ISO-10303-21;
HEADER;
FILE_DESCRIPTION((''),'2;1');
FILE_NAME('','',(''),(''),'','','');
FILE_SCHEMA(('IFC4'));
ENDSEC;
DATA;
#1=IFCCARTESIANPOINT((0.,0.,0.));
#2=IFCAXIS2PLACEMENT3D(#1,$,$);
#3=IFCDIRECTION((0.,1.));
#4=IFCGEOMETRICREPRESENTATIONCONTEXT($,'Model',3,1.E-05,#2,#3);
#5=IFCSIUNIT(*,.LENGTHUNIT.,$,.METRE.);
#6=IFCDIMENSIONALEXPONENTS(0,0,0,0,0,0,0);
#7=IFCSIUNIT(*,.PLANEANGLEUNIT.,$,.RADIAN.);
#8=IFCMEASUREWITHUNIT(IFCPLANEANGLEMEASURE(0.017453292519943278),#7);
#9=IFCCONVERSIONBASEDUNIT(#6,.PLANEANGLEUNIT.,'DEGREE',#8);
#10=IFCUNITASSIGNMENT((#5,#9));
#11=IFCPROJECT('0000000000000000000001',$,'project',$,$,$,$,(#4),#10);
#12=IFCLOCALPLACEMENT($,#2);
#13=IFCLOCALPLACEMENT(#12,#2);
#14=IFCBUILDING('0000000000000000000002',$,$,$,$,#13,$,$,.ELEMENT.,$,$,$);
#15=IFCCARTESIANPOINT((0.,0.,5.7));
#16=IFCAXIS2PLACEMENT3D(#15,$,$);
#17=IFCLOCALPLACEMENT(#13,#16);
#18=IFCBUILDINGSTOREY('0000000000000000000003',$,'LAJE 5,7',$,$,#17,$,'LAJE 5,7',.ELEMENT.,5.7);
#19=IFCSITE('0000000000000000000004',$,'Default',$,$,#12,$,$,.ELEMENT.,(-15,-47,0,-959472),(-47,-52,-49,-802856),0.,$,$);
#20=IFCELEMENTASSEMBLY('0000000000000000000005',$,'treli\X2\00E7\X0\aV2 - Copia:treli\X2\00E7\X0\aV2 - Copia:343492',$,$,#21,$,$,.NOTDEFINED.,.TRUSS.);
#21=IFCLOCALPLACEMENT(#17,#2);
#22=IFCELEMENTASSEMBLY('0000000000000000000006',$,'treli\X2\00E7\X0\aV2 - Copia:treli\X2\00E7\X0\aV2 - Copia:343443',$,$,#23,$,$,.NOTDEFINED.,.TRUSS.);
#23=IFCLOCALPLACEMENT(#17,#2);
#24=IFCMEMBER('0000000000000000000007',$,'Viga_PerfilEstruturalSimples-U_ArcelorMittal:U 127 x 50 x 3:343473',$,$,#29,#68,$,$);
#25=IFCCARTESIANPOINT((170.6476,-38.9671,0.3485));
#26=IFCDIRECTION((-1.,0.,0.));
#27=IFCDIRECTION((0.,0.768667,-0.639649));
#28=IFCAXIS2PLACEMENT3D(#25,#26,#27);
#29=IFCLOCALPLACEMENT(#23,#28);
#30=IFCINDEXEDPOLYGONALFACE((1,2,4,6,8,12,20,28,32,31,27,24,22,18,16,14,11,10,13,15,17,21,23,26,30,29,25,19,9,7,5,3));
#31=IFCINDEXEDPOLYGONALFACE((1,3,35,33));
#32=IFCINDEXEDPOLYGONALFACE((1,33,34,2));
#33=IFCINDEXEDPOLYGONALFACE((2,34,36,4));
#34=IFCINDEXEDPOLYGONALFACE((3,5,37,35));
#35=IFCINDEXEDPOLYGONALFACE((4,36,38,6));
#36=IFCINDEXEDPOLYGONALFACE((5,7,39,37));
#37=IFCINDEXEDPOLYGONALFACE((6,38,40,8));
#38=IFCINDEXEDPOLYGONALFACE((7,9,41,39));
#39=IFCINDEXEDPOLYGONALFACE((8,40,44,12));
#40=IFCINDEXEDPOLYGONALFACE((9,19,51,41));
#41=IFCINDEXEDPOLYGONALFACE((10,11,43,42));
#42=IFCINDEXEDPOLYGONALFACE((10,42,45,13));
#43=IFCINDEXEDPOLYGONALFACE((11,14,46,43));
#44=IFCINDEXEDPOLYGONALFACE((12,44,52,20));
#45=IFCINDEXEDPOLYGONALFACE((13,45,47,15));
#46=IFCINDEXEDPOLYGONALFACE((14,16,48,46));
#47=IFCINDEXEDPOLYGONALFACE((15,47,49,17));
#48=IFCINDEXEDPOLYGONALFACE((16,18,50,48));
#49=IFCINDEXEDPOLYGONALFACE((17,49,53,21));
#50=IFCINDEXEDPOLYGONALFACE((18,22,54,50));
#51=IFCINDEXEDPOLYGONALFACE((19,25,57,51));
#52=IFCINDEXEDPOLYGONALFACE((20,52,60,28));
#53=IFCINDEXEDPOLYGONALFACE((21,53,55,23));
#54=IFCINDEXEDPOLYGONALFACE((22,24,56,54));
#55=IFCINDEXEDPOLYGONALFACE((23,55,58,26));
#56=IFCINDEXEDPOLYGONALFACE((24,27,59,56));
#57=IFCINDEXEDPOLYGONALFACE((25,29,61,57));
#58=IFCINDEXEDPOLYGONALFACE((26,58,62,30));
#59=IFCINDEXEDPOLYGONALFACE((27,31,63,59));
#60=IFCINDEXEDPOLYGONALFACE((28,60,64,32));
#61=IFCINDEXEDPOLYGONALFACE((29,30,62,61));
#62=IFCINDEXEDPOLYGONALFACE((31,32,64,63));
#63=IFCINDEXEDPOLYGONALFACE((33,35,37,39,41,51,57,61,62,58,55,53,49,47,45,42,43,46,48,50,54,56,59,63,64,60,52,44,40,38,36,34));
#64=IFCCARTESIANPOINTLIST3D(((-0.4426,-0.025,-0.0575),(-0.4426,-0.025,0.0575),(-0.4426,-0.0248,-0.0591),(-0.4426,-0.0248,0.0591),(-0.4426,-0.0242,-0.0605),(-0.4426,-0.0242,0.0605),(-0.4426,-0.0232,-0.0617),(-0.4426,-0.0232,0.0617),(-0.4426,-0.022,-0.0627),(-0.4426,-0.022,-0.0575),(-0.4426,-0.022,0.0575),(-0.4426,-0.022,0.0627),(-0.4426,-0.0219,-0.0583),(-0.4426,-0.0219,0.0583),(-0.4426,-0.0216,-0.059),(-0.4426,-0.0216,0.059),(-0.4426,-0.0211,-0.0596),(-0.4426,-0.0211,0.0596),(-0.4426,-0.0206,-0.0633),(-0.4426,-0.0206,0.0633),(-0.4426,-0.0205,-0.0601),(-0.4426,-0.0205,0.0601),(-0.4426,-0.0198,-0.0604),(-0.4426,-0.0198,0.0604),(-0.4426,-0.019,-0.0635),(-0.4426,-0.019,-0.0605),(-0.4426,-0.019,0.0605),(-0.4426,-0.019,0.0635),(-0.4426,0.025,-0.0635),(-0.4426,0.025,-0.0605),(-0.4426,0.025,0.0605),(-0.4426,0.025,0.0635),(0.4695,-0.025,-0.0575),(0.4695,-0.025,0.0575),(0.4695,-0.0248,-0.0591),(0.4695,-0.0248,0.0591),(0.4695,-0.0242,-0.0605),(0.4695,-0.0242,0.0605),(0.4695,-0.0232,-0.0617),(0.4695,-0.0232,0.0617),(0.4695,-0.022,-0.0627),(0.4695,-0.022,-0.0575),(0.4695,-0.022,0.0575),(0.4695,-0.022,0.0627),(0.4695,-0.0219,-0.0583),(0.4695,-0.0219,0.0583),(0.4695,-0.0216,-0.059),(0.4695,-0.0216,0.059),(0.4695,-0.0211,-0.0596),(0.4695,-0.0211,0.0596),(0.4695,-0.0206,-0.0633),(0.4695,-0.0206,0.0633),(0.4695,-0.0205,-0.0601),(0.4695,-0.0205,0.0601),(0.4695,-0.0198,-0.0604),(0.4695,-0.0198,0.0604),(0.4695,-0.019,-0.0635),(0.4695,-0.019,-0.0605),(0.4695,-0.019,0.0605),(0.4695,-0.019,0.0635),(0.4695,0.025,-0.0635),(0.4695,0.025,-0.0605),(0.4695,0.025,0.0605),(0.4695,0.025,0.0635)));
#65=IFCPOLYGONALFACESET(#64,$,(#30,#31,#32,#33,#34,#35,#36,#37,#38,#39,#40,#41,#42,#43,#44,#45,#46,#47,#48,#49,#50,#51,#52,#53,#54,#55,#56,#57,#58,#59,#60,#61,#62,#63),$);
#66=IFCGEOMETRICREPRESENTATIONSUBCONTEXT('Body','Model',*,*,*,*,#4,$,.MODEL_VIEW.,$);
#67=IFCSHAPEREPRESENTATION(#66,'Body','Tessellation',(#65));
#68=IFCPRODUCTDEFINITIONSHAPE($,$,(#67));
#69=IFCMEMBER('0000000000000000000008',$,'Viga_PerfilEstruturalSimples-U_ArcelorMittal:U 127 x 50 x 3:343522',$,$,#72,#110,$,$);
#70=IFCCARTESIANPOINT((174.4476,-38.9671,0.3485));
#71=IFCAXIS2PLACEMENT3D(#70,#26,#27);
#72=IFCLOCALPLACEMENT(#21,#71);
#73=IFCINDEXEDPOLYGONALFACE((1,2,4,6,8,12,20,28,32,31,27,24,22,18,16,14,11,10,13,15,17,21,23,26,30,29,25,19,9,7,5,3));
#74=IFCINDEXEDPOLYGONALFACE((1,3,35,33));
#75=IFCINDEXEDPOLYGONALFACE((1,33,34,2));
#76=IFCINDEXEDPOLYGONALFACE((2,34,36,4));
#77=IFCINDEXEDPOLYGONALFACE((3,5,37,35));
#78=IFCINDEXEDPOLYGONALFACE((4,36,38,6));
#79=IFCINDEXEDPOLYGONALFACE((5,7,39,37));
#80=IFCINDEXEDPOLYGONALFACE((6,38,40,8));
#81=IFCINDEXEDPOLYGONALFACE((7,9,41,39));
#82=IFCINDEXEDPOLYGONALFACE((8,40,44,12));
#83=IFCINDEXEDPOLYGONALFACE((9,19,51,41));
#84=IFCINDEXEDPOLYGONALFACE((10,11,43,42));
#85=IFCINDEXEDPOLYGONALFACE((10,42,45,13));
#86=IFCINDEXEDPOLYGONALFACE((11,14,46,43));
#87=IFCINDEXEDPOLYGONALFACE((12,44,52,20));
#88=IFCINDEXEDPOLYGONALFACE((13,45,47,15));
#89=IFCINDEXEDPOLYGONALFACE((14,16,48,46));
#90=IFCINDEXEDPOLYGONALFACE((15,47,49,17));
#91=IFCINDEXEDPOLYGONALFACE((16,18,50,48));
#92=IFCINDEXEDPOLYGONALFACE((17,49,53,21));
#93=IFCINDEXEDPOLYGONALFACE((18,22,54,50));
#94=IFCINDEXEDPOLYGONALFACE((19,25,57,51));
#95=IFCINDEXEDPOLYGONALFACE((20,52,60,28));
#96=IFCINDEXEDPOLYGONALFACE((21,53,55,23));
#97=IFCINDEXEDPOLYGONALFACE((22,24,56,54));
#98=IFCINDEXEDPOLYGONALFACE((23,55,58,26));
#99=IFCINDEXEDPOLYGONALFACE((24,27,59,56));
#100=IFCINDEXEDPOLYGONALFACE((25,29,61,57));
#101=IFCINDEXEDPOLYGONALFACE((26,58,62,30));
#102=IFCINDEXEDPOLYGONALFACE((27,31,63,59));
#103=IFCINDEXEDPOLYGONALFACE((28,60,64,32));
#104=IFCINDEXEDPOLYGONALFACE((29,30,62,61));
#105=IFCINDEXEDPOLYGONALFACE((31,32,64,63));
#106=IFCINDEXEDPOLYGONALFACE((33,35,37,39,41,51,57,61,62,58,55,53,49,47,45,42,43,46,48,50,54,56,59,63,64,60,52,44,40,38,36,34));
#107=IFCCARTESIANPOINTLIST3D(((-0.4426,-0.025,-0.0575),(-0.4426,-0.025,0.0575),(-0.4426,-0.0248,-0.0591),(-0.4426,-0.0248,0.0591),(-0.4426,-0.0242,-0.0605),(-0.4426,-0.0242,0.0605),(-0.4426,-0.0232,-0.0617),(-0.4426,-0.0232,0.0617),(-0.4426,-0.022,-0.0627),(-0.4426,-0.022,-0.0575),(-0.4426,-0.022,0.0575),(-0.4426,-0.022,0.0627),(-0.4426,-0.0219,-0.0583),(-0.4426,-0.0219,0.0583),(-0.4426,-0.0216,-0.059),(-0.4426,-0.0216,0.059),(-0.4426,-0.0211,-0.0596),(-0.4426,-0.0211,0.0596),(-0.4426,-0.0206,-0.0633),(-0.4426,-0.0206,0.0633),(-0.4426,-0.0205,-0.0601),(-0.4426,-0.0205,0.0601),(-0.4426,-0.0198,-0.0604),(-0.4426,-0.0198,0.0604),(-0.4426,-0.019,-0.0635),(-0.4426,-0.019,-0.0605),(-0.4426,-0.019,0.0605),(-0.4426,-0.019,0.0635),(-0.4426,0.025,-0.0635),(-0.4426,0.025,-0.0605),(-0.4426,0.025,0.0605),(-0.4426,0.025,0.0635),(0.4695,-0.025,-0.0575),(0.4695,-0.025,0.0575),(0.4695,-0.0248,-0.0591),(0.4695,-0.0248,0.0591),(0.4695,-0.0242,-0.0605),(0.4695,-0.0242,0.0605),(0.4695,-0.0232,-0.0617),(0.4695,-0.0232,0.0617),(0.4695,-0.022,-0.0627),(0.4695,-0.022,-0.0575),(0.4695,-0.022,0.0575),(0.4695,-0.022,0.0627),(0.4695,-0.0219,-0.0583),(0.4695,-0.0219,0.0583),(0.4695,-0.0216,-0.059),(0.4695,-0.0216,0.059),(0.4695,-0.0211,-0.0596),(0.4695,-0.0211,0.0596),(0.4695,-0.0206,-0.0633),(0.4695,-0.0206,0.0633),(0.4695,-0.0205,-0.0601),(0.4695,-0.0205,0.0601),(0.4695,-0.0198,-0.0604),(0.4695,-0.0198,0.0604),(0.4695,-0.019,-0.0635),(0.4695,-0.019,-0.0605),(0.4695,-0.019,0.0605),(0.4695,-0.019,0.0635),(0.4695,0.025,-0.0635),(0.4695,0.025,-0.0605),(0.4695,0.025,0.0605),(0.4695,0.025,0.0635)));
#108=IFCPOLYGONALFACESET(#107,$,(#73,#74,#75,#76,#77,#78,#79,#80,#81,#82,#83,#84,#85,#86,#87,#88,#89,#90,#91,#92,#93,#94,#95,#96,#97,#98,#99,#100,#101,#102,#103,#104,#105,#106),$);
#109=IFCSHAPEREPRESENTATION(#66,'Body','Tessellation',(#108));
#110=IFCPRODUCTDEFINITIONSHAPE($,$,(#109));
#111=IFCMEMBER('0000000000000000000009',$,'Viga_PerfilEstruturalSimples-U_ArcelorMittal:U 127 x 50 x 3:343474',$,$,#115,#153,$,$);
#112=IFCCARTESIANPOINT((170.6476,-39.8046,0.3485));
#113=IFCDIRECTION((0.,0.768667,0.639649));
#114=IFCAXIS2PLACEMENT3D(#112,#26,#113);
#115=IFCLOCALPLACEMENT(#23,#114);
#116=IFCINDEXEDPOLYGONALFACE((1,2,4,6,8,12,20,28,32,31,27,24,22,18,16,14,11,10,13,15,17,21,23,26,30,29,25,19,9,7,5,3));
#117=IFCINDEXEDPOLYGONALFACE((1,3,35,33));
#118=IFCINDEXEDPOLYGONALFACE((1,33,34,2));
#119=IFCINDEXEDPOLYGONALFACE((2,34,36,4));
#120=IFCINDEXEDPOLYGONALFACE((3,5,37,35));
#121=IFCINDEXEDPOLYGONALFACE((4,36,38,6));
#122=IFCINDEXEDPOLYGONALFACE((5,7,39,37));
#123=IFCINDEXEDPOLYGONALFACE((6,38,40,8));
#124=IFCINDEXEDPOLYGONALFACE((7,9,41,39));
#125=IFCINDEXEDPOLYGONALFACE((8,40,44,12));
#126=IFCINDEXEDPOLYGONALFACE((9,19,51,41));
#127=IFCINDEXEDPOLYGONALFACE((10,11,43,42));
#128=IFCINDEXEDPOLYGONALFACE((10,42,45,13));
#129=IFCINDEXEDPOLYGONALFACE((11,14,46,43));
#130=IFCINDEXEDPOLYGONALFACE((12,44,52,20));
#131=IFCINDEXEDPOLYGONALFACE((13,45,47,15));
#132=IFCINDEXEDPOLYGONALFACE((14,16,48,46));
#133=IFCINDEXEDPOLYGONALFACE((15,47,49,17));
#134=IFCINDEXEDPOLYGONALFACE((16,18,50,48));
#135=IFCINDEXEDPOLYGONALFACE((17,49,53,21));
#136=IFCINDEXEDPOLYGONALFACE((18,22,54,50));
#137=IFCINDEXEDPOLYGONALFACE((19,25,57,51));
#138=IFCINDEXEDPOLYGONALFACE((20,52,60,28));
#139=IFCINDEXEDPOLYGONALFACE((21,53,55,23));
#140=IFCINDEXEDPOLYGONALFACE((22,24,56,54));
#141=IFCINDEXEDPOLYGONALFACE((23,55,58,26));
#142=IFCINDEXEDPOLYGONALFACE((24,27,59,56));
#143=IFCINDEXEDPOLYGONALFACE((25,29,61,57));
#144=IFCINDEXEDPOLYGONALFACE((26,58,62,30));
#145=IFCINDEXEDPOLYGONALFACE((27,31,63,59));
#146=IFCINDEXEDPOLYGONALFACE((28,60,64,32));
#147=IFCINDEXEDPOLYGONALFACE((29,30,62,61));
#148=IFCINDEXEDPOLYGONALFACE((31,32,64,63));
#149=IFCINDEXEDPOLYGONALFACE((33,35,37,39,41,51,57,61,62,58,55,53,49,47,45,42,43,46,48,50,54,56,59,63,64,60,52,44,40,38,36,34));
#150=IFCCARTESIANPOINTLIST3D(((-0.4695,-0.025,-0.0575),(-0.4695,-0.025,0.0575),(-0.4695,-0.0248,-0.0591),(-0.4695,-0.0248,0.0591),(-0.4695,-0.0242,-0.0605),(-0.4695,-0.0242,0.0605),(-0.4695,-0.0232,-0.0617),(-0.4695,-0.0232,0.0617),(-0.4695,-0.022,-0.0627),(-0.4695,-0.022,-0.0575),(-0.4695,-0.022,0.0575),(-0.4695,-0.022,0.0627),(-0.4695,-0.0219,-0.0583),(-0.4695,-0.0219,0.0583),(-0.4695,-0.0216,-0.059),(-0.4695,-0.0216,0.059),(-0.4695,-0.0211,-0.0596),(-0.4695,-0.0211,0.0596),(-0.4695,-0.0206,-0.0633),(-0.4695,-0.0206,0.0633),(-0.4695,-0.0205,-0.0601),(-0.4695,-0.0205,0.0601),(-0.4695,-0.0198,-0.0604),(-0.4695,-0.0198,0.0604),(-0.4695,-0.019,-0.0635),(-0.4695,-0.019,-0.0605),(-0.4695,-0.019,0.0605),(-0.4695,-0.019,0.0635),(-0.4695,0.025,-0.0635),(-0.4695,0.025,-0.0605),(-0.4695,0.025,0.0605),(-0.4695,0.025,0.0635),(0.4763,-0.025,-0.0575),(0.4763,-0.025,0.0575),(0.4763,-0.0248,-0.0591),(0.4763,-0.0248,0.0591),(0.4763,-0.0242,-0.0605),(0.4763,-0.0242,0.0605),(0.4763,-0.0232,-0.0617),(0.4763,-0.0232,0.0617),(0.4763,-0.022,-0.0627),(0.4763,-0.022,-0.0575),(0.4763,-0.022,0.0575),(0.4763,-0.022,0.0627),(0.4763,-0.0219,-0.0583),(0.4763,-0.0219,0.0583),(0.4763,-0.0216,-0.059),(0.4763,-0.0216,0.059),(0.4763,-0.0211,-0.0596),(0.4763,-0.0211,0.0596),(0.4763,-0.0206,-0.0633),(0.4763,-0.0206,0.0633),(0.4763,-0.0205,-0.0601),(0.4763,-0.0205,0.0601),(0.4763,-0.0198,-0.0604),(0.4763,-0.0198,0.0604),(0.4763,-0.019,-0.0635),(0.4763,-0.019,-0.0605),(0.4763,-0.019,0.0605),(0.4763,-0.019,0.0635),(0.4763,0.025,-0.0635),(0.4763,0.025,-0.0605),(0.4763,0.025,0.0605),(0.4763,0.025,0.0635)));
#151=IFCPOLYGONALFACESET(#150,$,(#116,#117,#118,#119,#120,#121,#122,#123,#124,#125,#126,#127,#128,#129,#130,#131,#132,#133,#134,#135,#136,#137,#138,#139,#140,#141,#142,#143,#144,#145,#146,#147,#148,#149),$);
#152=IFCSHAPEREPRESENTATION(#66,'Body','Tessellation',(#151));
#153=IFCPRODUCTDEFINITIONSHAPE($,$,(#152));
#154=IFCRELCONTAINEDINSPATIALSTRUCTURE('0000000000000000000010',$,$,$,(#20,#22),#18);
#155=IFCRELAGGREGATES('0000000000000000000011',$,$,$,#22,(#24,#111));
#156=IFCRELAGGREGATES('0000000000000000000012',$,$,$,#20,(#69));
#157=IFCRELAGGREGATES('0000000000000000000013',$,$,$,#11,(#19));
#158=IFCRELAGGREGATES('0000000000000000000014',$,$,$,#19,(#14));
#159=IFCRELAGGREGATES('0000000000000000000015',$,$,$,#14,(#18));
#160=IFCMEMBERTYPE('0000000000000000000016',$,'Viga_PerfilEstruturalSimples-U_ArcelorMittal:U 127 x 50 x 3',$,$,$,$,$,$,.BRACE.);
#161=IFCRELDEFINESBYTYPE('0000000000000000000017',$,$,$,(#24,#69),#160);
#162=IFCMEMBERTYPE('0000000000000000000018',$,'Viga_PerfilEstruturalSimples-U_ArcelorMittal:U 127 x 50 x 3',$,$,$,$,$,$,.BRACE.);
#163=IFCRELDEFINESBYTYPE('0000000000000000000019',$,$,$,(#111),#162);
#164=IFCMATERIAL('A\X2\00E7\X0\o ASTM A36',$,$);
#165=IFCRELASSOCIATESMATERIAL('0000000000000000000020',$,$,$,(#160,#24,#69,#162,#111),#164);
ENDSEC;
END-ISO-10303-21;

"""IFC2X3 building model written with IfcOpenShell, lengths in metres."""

from ifc_helpers import new_model, entity, si_unit, converted_unit, direction, frame, frame_2d, origin, place, context, subcontext, project, spatial, polyline, circle_curve, parameter, trimmed, segment, composite_curve, outline, extrude, source, transform, mapped, material, type_object, type_shapes, element, aggregate, save


model = new_model("IFC2X3")

# Units and contexts
model_context = context("Model", 3, precision=1e-05, world=origin(), true_north=direction((0.0, 1.0)))
body_context = subcontext(model_context, "Body", "Model", "MODEL_VIEW")
ifc_project = project(units=[si_unit("LENGTHUNIT", "METRE"), converted_unit("PLANEANGLEUNIT", "DEGREE", entity("IfcPlaneAngleMeasure", 0.017453292519943278), si_unit("PLANEANGLEUNIT", "RADIAN"), dimensions=[0, 0, 0, 0, 0, 0, 0])], contexts=[model_context])

# Site, building, storey
site_placement = place(None, origin())
site = spatial("IfcSite", under=ifc_project, at=site_placement, Name="Default", CompositionType="ELEMENT", RefLatitude=(-15, -47, 0, -959472), RefLongitude=(-47, -52, -49, -802856), RefElevation=0.0)
building_placement = place(site_placement, origin())
building = spatial("IfcBuilding", under=site, at=building_placement, CompositionType="ELEMENT")
storey_placement = place(building_placement, frame((0.0, 0.0, 5.7)))
storey = spatial("IfcBuildingStorey", under=building, at=storey_placement, Name="LAJE 5,7", LongName="LAJE 5,7", CompositionType="ELEMENT", Elevation=5.7)

# Element assembly
assembly_1_placement = place(storey_placement, origin())
assembly_1 = element("IfcElementAssembly", 1, at=assembly_1_placement, inside=storey, Name="treliçaV2 - Copia:treliçaV2 - Copia:343492", AssemblyPlace="NOTDEFINED", PredefinedType="TRUSS")
ifc_material = material(Name="Aço ASTM A36")

# Element assembly
assembly_2_placement = place(storey_placement, origin())
assembly_2 = element("IfcElementAssembly", 2, at=assembly_2_placement, inside=storey, Name="treliçaV2 - Copia:treliçaV2 - Copia:343443", AssemblyPlace="NOTDEFINED", PredefinedType="TRUSS")

# Members
member_type_1 = type_object("IfcMemberType", Name="Viga_PerfilEstruturalSimples-U_ArcelorMittal:U 127 x 50 x 3", PredefinedType="BRACE", material=ifc_material)
shared_shape_1 = source(origin(), body_context, "Body", "SweptSolid", [
    extrude(outline(composite_curve([segment(polyline([(-0.0575, -0.0192), (0.0575, -0.0192)]), True, "CONTINUOUS"), segment(trimmed(circle_curve(frame_2d((0.0575, -0.0132), x_axis=(0.0, 1.0)), 0.006), [parameter(180.0)], [parameter(270.0)], True, "PARAMETER"), True, "CONTINUOUS"), segment(polyline([(0.0635, -0.0132), (0.0635, 0.0308)]), True, "CONTINUOUS"), segment(polyline([(0.0635, 0.0308), (0.0605, 0.0308)]), True, "CONTINUOUS"), segment(polyline([(0.0605, 0.0308), (0.0605, -0.0132)]), True, "CONTINUOUS"), segment(trimmed(circle_curve(frame_2d((0.0575, -0.0132), x_axis=(0.0, 1.0)), 0.003), [parameter(180.0)], [parameter(270.0)], True, "PARAMETER"), False, "CONTINUOUS"), segment(polyline([(0.0575, -0.0162), (-0.0575, -0.0162)]), True, "CONTINUOUS"), segment(trimmed(circle_curve(frame_2d((-0.0575, -0.0132), x_axis=(0.0, 1.0)), 0.003), [parameter(90.0)], [parameter(180.0)], True, "PARAMETER"), False, "CONTINUOUS"), segment(polyline([(-0.0605, -0.0132), (-0.0605, 0.0308)]), True, "CONTINUOUS"), segment(polyline([(-0.0605, 0.0308), (-0.0635, 0.0308)]), True, "CONTINUOUS"), segment(polyline([(-0.0635, 0.0308), (-0.0635, -0.0132)]), True, "CONTINUOUS"), segment(trimmed(circle_curve(frame_2d((-0.0575, -0.0132), x_axis=(0.0, 1.0)), 0.006), [parameter(90.0)], [parameter(180.0)], True, "PARAMETER"), True, "CONTINUOUS")], self_intersect=False)), frame((-0.4426, -0.0058, 0.0), z_axis=(1.0, 0.0, 0.0), x_axis=(0.0, 0.0, -1.0)), (0.0, 0.0, 1.0), 0.9121),
])
type_shapes(member_type_1, [shared_shape_1])
member_1_placement = place(assembly_2_placement, frame((170.6476, -38.9671, 0.3485), z_axis=(-1.0, 0.0, 0.0), x_axis=(0.0, 0.768667, -0.639649)))
member_1 = element("IfcMember", 3, at=member_1_placement, type_object=member_type_1, material=ifc_material, Name="Viga_PerfilEstruturalSimples-U_ArcelorMittal:U 127 x 50 x 3:343473", context=body_context, shape_type="MappedRepresentation", body=[
    mapped(shared_shape_1, transform((0.0, 0.0, 0.0), scale=1.0)),
])
member_2_placement = place(assembly_1_placement, frame((174.4476, -38.9671, 0.3485), z_axis=(-1.0, 0.0, 0.0), x_axis=(0.0, 0.768667, -0.639649)))
member_2 = element("IfcMember", 4, at=member_2_placement, type_object=member_type_1, material=ifc_material, Name="Viga_PerfilEstruturalSimples-U_ArcelorMittal:U 127 x 50 x 3:343522", context=body_context, shape_type="MappedRepresentation", body=[
    mapped(shared_shape_1, transform((0.0, 0.0, 0.0), scale=1.0)),
])
member_type_2 = type_object("IfcMemberType", Name="Viga_PerfilEstruturalSimples-U_ArcelorMittal:U 127 x 50 x 3", PredefinedType="BRACE", material=ifc_material)
shared_shape_2 = source(origin(), body_context, "Body", "SweptSolid", [
    extrude(outline(composite_curve([segment(polyline([(-0.0575, -0.0192), (0.0575, -0.0192)]), True, "CONTINUOUS"), segment(trimmed(circle_curve(frame_2d((0.0575, -0.0132), x_axis=(0.0, 1.0)), 0.006), [parameter(180.0)], [parameter(270.0)], True, "PARAMETER"), True, "CONTINUOUS"), segment(polyline([(0.0635, -0.0132), (0.0635, 0.0308)]), True, "CONTINUOUS"), segment(polyline([(0.0635, 0.0308), (0.0605, 0.0308)]), True, "CONTINUOUS"), segment(polyline([(0.0605, 0.0308), (0.0605, -0.0132)]), True, "CONTINUOUS"), segment(trimmed(circle_curve(frame_2d((0.0575, -0.0132), x_axis=(0.0, 1.0)), 0.003), [parameter(180.0)], [parameter(270.0)], True, "PARAMETER"), False, "CONTINUOUS"), segment(polyline([(0.0575, -0.0162), (-0.0575, -0.0162)]), True, "CONTINUOUS"), segment(trimmed(circle_curve(frame_2d((-0.0575, -0.0132), x_axis=(0.0, 1.0)), 0.003), [parameter(90.0)], [parameter(180.0)], True, "PARAMETER"), False, "CONTINUOUS"), segment(polyline([(-0.0605, -0.0132), (-0.0605, 0.0308)]), True, "CONTINUOUS"), segment(polyline([(-0.0605, 0.0308), (-0.0635, 0.0308)]), True, "CONTINUOUS"), segment(polyline([(-0.0635, 0.0308), (-0.0635, -0.0132)]), True, "CONTINUOUS"), segment(trimmed(circle_curve(frame_2d((-0.0575, -0.0132), x_axis=(0.0, 1.0)), 0.006), [parameter(90.0)], [parameter(180.0)], True, "PARAMETER"), True, "CONTINUOUS")], self_intersect=False)), frame((-0.4695, -0.0058, 0.0), z_axis=(1.0, 0.0, 0.0), x_axis=(0.0, 0.0, -1.0)), (0.0, 0.0, 1.0), 0.9459),
])
type_shapes(member_type_2, [shared_shape_2])
member_3_placement = place(assembly_2_placement, frame((170.6476, -39.8046, 0.3485), z_axis=(-1.0, 0.0, 0.0), x_axis=(0.0, 0.768667, 0.639649)))
member_3 = element("IfcMember", 5, at=member_3_placement, type_object=member_type_2, material=ifc_material, Name="Viga_PerfilEstruturalSimples-U_ArcelorMittal:U 127 x 50 x 3:343474", context=body_context, shape_type="MappedRepresentation", body=[
    mapped(shared_shape_2, transform((0.0, 0.0, 0.0), scale=1.0)),
])
aggregate(assembly_2, [member_1, member_3])
aggregate(assembly_1, [member_2])

save(model, "model.ifc")
